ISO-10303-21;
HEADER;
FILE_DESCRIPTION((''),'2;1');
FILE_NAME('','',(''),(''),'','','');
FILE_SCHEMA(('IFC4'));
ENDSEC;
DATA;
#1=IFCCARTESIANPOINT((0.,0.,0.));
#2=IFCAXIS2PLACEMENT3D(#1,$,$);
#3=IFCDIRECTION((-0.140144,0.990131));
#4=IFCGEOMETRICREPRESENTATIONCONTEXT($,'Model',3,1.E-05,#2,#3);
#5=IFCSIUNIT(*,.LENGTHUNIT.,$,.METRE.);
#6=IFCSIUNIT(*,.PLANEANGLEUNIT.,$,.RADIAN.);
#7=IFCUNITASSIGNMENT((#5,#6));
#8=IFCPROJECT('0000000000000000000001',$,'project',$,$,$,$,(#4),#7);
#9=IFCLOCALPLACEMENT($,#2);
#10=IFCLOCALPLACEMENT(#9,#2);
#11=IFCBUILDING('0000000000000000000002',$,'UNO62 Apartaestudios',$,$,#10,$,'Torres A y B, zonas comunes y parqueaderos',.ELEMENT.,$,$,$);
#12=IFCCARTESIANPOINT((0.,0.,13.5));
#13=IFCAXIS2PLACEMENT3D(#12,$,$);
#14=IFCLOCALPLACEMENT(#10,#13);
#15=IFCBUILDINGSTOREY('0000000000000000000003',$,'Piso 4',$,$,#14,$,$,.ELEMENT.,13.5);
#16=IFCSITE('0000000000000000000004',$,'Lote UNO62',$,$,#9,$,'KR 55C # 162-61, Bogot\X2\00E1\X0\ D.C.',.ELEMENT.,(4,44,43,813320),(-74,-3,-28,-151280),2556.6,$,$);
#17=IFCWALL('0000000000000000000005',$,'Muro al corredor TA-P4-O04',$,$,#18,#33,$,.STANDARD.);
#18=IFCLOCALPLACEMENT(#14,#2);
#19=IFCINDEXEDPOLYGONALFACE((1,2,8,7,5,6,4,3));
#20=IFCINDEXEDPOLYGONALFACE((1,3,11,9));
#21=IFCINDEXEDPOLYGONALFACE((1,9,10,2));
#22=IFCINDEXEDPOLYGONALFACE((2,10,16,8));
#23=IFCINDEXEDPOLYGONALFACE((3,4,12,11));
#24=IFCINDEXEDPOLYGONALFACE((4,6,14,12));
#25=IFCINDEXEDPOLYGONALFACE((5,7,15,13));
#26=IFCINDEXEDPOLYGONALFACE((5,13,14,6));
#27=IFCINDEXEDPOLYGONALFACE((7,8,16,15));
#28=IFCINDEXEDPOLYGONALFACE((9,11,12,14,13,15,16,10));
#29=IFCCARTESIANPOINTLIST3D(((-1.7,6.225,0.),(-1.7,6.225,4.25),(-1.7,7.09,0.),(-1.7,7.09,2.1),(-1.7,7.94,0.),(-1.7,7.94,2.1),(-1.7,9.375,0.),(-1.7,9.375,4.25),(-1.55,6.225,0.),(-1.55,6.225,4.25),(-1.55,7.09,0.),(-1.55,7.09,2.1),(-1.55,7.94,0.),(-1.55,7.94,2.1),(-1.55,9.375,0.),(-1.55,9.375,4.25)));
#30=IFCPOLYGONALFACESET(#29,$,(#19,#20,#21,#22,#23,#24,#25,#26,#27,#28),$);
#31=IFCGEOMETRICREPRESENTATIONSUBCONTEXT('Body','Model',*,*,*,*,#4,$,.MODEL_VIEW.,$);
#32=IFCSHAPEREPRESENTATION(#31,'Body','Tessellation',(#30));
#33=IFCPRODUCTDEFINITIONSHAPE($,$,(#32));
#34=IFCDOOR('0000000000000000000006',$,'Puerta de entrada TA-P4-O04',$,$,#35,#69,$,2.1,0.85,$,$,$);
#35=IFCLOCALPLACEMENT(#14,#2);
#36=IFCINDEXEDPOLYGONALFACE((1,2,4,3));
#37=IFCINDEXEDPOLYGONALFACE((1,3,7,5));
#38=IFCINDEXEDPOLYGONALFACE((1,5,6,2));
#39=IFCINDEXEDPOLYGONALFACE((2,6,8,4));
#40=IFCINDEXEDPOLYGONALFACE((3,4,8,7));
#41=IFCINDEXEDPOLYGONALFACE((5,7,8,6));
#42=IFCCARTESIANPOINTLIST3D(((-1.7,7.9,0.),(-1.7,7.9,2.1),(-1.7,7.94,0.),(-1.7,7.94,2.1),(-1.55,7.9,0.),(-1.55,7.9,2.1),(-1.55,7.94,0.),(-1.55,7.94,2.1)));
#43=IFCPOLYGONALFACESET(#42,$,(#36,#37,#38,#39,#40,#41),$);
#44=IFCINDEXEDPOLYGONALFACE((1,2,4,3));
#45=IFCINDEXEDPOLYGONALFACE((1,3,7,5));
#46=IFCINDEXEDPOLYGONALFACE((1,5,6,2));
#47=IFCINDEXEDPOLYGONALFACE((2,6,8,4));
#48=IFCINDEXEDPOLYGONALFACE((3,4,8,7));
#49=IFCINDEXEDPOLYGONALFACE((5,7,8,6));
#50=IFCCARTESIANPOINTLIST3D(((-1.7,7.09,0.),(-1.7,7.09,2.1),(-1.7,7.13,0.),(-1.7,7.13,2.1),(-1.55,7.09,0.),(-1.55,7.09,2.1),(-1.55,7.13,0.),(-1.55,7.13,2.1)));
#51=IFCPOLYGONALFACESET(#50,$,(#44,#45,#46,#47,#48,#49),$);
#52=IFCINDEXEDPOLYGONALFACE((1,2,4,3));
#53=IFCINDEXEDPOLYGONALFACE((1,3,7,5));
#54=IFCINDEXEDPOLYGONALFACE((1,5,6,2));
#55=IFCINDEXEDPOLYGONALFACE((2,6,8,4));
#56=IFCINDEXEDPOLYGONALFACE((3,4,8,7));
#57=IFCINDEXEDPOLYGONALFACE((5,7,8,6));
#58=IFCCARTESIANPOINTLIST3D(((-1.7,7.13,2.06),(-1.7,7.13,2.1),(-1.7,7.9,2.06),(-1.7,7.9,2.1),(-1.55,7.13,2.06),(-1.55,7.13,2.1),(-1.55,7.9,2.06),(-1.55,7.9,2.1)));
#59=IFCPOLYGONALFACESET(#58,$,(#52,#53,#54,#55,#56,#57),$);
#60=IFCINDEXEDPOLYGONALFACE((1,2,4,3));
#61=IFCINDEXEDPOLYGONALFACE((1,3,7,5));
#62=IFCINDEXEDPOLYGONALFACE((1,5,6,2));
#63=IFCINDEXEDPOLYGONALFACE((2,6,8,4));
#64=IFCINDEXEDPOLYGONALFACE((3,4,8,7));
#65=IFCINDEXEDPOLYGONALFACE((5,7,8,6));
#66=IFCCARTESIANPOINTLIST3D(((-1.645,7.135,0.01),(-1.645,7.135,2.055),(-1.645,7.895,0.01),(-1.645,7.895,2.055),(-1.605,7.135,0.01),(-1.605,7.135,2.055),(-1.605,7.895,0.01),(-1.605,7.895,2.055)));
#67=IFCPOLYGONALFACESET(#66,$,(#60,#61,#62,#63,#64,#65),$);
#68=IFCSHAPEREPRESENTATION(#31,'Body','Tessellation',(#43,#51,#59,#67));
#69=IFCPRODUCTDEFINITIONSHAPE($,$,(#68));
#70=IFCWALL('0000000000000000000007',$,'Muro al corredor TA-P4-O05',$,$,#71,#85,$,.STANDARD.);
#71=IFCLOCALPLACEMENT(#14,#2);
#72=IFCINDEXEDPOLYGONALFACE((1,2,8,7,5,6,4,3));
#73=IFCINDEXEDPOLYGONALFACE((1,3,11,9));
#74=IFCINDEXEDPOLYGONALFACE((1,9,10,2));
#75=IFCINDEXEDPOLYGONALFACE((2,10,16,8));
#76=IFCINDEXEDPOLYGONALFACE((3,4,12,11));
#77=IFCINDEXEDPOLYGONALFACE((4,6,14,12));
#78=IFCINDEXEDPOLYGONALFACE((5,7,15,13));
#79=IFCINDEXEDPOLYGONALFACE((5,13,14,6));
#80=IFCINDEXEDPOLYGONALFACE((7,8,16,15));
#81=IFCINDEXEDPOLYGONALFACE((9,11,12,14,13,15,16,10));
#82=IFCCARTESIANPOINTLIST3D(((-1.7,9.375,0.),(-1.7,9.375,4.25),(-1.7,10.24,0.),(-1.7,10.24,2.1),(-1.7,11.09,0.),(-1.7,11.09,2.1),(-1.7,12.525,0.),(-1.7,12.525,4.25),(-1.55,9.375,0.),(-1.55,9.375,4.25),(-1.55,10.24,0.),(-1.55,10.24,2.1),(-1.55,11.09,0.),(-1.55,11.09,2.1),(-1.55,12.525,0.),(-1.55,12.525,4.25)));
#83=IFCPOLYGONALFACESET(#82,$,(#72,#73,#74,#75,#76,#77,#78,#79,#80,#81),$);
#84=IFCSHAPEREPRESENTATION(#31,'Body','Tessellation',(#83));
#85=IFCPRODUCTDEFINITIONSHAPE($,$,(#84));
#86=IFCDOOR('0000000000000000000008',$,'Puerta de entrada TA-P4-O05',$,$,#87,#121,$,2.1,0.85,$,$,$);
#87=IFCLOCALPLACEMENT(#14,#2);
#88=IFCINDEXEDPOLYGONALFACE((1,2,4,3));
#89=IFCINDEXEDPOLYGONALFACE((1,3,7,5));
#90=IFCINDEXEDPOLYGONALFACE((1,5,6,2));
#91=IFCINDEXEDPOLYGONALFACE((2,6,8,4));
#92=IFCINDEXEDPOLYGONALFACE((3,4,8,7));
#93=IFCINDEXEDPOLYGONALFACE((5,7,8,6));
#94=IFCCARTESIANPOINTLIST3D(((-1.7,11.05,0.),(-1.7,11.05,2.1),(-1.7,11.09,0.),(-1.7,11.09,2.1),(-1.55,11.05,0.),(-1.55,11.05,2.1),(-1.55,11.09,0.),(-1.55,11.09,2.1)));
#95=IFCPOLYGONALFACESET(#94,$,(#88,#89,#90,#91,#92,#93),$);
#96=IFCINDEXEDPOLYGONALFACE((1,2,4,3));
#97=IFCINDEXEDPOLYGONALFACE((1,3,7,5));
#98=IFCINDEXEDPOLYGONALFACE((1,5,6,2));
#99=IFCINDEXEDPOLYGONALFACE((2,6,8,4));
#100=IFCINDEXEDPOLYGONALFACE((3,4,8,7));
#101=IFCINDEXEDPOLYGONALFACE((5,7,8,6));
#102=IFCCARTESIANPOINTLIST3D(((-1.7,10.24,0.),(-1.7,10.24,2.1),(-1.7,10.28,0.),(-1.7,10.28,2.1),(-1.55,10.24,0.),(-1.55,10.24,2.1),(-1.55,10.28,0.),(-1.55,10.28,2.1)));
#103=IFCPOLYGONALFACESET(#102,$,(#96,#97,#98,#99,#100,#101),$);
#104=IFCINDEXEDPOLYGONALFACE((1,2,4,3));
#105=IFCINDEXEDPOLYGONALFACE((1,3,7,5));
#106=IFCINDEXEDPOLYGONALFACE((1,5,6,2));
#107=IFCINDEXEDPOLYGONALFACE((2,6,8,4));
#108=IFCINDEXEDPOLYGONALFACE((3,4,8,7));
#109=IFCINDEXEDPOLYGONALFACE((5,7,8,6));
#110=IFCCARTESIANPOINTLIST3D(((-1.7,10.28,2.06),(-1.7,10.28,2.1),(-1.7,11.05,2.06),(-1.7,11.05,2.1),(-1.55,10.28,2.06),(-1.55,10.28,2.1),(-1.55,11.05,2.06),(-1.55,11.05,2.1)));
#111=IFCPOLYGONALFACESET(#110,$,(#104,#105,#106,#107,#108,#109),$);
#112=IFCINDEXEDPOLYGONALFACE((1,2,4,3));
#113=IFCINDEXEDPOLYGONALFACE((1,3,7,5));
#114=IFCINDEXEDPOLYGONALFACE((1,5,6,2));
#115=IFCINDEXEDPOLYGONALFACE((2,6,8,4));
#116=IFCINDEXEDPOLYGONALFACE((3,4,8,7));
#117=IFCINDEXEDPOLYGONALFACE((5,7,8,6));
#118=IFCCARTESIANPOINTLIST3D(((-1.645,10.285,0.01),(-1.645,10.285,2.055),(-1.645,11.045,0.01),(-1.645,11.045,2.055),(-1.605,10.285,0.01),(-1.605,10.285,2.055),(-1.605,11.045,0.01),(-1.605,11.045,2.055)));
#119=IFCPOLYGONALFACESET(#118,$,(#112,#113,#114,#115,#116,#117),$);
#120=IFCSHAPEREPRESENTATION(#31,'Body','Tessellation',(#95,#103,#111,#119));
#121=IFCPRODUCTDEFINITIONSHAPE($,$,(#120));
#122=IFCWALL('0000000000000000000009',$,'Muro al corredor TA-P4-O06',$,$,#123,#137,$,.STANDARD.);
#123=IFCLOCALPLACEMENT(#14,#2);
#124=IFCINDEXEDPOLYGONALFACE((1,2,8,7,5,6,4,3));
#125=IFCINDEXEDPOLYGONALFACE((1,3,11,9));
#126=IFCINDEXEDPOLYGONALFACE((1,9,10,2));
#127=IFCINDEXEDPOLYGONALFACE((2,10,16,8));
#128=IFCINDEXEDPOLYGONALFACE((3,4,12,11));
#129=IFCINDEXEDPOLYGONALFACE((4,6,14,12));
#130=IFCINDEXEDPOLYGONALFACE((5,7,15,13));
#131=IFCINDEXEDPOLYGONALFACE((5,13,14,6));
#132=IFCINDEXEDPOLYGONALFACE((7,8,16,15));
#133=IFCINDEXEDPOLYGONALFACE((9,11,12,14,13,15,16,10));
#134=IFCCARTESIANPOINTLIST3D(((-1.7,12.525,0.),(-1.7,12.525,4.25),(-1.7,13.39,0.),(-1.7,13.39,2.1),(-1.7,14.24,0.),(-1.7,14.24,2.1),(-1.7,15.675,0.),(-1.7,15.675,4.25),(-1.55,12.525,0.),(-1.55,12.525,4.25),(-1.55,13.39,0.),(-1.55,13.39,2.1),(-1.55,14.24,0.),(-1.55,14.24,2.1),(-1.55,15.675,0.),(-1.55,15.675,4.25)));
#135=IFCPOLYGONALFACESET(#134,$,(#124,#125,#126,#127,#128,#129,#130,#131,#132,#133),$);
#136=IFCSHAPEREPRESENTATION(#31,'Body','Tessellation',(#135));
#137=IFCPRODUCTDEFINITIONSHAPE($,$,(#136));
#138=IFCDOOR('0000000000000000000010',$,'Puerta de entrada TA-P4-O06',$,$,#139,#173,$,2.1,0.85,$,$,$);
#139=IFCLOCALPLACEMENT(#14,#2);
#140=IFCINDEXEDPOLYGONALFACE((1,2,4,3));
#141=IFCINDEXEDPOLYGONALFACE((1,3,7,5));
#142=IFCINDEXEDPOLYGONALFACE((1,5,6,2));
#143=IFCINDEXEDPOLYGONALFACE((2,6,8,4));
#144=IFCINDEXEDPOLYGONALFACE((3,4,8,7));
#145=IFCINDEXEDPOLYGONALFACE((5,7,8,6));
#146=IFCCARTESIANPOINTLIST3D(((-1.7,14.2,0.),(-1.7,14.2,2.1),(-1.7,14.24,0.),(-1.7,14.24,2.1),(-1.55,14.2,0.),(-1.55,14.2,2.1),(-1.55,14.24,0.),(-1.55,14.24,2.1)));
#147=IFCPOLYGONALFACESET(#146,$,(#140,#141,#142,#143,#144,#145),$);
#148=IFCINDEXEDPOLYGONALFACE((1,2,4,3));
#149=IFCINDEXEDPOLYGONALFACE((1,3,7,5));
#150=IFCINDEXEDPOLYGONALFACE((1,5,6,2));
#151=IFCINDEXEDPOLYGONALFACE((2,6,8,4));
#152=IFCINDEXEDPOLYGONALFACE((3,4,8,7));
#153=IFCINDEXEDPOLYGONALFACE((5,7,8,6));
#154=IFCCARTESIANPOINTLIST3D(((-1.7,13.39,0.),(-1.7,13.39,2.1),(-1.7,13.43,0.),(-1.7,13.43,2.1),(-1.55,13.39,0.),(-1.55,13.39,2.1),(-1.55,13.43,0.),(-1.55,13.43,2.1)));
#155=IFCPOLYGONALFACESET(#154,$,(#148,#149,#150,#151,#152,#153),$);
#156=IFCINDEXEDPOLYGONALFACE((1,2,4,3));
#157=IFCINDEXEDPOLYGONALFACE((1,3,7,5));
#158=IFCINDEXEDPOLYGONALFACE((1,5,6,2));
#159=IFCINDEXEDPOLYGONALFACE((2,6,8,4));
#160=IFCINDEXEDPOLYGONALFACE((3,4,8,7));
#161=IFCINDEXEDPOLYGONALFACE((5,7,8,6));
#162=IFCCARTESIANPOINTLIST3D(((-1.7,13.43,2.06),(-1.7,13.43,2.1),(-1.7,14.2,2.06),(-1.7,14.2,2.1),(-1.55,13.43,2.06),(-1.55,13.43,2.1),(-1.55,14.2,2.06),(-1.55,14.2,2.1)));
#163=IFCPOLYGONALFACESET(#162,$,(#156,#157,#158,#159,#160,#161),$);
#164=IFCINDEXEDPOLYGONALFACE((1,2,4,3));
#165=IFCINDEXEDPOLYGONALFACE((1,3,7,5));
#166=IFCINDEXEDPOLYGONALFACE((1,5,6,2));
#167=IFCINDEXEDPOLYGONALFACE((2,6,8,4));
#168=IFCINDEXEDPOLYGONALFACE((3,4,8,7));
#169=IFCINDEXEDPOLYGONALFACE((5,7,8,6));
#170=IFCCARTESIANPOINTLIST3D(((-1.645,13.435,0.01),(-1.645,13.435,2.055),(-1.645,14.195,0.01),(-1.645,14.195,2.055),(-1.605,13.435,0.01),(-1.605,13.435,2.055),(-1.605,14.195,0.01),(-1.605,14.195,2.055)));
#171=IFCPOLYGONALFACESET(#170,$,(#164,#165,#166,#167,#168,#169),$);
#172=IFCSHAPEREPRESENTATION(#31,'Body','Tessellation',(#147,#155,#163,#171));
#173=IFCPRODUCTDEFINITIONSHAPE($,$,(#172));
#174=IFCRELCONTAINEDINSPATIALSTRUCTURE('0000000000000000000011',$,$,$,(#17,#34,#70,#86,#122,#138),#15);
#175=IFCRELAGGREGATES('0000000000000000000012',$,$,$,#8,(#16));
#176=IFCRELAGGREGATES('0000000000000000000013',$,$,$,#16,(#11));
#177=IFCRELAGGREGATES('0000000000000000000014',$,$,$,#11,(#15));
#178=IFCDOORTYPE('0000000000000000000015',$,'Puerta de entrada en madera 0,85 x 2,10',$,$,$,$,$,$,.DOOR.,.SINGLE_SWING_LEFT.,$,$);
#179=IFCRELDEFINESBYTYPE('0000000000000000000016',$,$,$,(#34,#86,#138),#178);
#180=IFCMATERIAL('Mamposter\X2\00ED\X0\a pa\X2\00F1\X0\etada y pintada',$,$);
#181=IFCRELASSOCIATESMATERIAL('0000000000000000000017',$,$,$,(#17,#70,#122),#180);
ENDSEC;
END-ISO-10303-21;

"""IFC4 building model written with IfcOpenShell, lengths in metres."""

from ifc_helpers import new_model, si_unit, direction, frame, frame_2d, origin, place, context, subcontext, project, spatial, rectangle, extrude, source, transform, mapped, material, type_object, type_shapes, element, fill, save


model = new_model("IFC4")

# Units and contexts
model_context = context("Model", 3, precision=1e-05, world=origin(), true_north=direction((-0.140144, 0.990131)))
body_context = subcontext(model_context, "Body", "Model", "MODEL_VIEW")
ifc_project = project(units=[si_unit("LENGTHUNIT", "METRE"), si_unit("PLANEANGLEUNIT", "RADIAN")], contexts=[model_context])

# Site, building, storey
site_placement = place(None, origin())
site = spatial("IfcSite", under=ifc_project, at=site_placement, Name="Lote UNO62", LongName="KR 55C # 162-61, Bogotá D.C.", CompositionType="ELEMENT", RefLatitude=(4, 44, 43, 813320), RefLongitude=(-74, -3, -28, -151280), RefElevation=2556.6)
building_placement = place(site_placement, origin())
building = spatial("IfcBuilding", under=site, at=building_placement, Name="UNO62 Apartaestudios", LongName="Torres A y B, zonas comunes y parqueaderos", CompositionType="ELEMENT")
storey_placement = place(building_placement, frame((0.0, 0.0, 13.5)))
storey = spatial("IfcBuildingStorey", under=building, at=storey_placement, Name="Piso 4", CompositionType="ELEMENT", Elevation=13.5)

# Walls, openings, doors
ifc_material = material(Name="Mampostería pañetada y pintada")
door_type = type_object("IfcDoorType", Name="Puerta de entrada en madera 0,85 x 2,10", OperationType="SINGLE_SWING_LEFT", PredefinedType="DOOR")
shared_shape = source(origin(), body_context, "Body", "SweptSolid", [
    extrude(rectangle(XDim=0.15, YDim=0.04, at=frame_2d((-0.075, 1.38))), origin(), (0.0, 0.0, 1.0), 2.1),
    extrude(rectangle(XDim=0.15, YDim=0.04, at=frame_2d((-0.075, 2.19))), origin(), (0.0, 0.0, 1.0), 2.1),
    extrude(rectangle(XDim=0.15, YDim=0.77, at=frame_2d((-0.075, 1.785))), frame((0.0, 0.0, 2.06)), (0.0, 0.0, 1.0), 0.04),
    extrude(rectangle(XDim=0.04, YDim=0.76, at=frame_2d((-0.075, 1.785))), frame((0.0, 0.0, 0.01)), (0.0, 0.0, 1.0), 2.045),
])
type_shapes(door_type, [shared_shape])
wall_1_placement = place(storey_placement, origin())
wall_1 = element("IfcWall", 1, at=wall_1_placement, inside=storey, material=ifc_material, Name="Muro al corredor TA-P4-O04", PredefinedType="STANDARD", context=body_context, shape_type="SweptSolid", body=[
    extrude(rectangle(XDim=0.15, YDim=3.15, at=frame_2d((-1.625, 7.8))), origin(), (0.0, 0.0, 1.0), 4.25),
])
opening_1_placement = place(wall_1_placement, origin())
opening_1 = element("IfcOpeningElement", 2, at=opening_1_placement, cuts=wall_1, PredefinedType="OPENING", context=body_context, shape_type="SweptSolid", body=[
    extrude(rectangle(XDim=0.25, YDim=0.85, at=frame_2d((-1.625, 7.515))), origin(), (0.0, 0.0, 1.0), 2.1),
])
placement_1 = place(storey_placement, frame((-1.7, 9.3, 0.0), z_axis=(0.0, 0.0, 1.0), x_axis=(-1.0, 0.0, 0.0)))
door_1_placement = place(placement_1, origin())
door_1 = element("IfcDoor", 3, at=door_1_placement, inside=storey, type_object=door_type, Name="Puerta de entrada TA-P4-O04", OverallHeight=2.1, OverallWidth=0.85, context=body_context, shape_type="MappedRepresentation", body=[
    mapped(shared_shape, transform((0.0, 0.0, 0.0))),
])
fill(opening_1, door_1)
wall_2_placement = place(storey_placement, origin())
wall_2 = element("IfcWall", 4, at=wall_2_placement, inside=storey, material=ifc_material, Name="Muro al corredor TA-P4-O05", PredefinedType="STANDARD", context=body_context, shape_type="SweptSolid", body=[
    extrude(rectangle(XDim=0.15, YDim=3.15, at=frame_2d((-1.625, 10.95))), origin(), (0.0, 0.0, 1.0), 4.25),
])
opening_2_placement = place(wall_2_placement, origin())
opening_2 = element("IfcOpeningElement", 5, at=opening_2_placement, cuts=wall_2, PredefinedType="OPENING", context=body_context, shape_type="SweptSolid", body=[
    extrude(rectangle(XDim=0.25, YDim=0.85, at=frame_2d((-1.625, 10.665))), origin(), (0.0, 0.0, 1.0), 2.1),
])
placement_2 = place(storey_placement, frame((-1.7, 12.45, 0.0), z_axis=(0.0, 0.0, 1.0), x_axis=(-1.0, 0.0, 0.0)))
door_2_placement = place(placement_2, origin())
door_2 = element("IfcDoor", 6, at=door_2_placement, inside=storey, type_object=door_type, Name="Puerta de entrada TA-P4-O05", OverallHeight=2.1, OverallWidth=0.85, context=body_context, shape_type="MappedRepresentation", body=[
    mapped(shared_shape, transform((0.0, 0.0, 0.0))),
])
fill(opening_2, door_2)
wall_3_placement = place(storey_placement, origin())
wall_3 = element("IfcWall", 7, at=wall_3_placement, inside=storey, material=ifc_material, Name="Muro al corredor TA-P4-O06", PredefinedType="STANDARD", context=body_context, shape_type="SweptSolid", body=[
    extrude(rectangle(XDim=0.15, YDim=3.15, at=frame_2d((-1.625, 14.1))), origin(), (0.0, 0.0, 1.0), 4.25),
])
opening_3_placement = place(wall_3_placement, origin())
opening_3 = element("IfcOpeningElement", 8, at=opening_3_placement, cuts=wall_3, PredefinedType="OPENING", context=body_context, shape_type="SweptSolid", body=[
    extrude(rectangle(XDim=0.25, YDim=0.85, at=frame_2d((-1.625, 13.815))), origin(), (0.0, 0.0, 1.0), 2.1),
])
placement_3 = place(storey_placement, frame((-1.7, 15.6, 0.0), z_axis=(0.0, 0.0, 1.0), x_axis=(-1.0, 0.0, 0.0)))
door_3_placement = place(placement_3, origin())
door_3 = element("IfcDoor", 9, at=door_3_placement, inside=storey, type_object=door_type, Name="Puerta de entrada TA-P4-O06", OverallHeight=2.1, OverallWidth=0.85, context=body_context, shape_type="MappedRepresentation", body=[
    mapped(shared_shape, transform((0.0, 0.0, 0.0))),
])
fill(opening_3, door_3)

save(model, "model.ifc")
